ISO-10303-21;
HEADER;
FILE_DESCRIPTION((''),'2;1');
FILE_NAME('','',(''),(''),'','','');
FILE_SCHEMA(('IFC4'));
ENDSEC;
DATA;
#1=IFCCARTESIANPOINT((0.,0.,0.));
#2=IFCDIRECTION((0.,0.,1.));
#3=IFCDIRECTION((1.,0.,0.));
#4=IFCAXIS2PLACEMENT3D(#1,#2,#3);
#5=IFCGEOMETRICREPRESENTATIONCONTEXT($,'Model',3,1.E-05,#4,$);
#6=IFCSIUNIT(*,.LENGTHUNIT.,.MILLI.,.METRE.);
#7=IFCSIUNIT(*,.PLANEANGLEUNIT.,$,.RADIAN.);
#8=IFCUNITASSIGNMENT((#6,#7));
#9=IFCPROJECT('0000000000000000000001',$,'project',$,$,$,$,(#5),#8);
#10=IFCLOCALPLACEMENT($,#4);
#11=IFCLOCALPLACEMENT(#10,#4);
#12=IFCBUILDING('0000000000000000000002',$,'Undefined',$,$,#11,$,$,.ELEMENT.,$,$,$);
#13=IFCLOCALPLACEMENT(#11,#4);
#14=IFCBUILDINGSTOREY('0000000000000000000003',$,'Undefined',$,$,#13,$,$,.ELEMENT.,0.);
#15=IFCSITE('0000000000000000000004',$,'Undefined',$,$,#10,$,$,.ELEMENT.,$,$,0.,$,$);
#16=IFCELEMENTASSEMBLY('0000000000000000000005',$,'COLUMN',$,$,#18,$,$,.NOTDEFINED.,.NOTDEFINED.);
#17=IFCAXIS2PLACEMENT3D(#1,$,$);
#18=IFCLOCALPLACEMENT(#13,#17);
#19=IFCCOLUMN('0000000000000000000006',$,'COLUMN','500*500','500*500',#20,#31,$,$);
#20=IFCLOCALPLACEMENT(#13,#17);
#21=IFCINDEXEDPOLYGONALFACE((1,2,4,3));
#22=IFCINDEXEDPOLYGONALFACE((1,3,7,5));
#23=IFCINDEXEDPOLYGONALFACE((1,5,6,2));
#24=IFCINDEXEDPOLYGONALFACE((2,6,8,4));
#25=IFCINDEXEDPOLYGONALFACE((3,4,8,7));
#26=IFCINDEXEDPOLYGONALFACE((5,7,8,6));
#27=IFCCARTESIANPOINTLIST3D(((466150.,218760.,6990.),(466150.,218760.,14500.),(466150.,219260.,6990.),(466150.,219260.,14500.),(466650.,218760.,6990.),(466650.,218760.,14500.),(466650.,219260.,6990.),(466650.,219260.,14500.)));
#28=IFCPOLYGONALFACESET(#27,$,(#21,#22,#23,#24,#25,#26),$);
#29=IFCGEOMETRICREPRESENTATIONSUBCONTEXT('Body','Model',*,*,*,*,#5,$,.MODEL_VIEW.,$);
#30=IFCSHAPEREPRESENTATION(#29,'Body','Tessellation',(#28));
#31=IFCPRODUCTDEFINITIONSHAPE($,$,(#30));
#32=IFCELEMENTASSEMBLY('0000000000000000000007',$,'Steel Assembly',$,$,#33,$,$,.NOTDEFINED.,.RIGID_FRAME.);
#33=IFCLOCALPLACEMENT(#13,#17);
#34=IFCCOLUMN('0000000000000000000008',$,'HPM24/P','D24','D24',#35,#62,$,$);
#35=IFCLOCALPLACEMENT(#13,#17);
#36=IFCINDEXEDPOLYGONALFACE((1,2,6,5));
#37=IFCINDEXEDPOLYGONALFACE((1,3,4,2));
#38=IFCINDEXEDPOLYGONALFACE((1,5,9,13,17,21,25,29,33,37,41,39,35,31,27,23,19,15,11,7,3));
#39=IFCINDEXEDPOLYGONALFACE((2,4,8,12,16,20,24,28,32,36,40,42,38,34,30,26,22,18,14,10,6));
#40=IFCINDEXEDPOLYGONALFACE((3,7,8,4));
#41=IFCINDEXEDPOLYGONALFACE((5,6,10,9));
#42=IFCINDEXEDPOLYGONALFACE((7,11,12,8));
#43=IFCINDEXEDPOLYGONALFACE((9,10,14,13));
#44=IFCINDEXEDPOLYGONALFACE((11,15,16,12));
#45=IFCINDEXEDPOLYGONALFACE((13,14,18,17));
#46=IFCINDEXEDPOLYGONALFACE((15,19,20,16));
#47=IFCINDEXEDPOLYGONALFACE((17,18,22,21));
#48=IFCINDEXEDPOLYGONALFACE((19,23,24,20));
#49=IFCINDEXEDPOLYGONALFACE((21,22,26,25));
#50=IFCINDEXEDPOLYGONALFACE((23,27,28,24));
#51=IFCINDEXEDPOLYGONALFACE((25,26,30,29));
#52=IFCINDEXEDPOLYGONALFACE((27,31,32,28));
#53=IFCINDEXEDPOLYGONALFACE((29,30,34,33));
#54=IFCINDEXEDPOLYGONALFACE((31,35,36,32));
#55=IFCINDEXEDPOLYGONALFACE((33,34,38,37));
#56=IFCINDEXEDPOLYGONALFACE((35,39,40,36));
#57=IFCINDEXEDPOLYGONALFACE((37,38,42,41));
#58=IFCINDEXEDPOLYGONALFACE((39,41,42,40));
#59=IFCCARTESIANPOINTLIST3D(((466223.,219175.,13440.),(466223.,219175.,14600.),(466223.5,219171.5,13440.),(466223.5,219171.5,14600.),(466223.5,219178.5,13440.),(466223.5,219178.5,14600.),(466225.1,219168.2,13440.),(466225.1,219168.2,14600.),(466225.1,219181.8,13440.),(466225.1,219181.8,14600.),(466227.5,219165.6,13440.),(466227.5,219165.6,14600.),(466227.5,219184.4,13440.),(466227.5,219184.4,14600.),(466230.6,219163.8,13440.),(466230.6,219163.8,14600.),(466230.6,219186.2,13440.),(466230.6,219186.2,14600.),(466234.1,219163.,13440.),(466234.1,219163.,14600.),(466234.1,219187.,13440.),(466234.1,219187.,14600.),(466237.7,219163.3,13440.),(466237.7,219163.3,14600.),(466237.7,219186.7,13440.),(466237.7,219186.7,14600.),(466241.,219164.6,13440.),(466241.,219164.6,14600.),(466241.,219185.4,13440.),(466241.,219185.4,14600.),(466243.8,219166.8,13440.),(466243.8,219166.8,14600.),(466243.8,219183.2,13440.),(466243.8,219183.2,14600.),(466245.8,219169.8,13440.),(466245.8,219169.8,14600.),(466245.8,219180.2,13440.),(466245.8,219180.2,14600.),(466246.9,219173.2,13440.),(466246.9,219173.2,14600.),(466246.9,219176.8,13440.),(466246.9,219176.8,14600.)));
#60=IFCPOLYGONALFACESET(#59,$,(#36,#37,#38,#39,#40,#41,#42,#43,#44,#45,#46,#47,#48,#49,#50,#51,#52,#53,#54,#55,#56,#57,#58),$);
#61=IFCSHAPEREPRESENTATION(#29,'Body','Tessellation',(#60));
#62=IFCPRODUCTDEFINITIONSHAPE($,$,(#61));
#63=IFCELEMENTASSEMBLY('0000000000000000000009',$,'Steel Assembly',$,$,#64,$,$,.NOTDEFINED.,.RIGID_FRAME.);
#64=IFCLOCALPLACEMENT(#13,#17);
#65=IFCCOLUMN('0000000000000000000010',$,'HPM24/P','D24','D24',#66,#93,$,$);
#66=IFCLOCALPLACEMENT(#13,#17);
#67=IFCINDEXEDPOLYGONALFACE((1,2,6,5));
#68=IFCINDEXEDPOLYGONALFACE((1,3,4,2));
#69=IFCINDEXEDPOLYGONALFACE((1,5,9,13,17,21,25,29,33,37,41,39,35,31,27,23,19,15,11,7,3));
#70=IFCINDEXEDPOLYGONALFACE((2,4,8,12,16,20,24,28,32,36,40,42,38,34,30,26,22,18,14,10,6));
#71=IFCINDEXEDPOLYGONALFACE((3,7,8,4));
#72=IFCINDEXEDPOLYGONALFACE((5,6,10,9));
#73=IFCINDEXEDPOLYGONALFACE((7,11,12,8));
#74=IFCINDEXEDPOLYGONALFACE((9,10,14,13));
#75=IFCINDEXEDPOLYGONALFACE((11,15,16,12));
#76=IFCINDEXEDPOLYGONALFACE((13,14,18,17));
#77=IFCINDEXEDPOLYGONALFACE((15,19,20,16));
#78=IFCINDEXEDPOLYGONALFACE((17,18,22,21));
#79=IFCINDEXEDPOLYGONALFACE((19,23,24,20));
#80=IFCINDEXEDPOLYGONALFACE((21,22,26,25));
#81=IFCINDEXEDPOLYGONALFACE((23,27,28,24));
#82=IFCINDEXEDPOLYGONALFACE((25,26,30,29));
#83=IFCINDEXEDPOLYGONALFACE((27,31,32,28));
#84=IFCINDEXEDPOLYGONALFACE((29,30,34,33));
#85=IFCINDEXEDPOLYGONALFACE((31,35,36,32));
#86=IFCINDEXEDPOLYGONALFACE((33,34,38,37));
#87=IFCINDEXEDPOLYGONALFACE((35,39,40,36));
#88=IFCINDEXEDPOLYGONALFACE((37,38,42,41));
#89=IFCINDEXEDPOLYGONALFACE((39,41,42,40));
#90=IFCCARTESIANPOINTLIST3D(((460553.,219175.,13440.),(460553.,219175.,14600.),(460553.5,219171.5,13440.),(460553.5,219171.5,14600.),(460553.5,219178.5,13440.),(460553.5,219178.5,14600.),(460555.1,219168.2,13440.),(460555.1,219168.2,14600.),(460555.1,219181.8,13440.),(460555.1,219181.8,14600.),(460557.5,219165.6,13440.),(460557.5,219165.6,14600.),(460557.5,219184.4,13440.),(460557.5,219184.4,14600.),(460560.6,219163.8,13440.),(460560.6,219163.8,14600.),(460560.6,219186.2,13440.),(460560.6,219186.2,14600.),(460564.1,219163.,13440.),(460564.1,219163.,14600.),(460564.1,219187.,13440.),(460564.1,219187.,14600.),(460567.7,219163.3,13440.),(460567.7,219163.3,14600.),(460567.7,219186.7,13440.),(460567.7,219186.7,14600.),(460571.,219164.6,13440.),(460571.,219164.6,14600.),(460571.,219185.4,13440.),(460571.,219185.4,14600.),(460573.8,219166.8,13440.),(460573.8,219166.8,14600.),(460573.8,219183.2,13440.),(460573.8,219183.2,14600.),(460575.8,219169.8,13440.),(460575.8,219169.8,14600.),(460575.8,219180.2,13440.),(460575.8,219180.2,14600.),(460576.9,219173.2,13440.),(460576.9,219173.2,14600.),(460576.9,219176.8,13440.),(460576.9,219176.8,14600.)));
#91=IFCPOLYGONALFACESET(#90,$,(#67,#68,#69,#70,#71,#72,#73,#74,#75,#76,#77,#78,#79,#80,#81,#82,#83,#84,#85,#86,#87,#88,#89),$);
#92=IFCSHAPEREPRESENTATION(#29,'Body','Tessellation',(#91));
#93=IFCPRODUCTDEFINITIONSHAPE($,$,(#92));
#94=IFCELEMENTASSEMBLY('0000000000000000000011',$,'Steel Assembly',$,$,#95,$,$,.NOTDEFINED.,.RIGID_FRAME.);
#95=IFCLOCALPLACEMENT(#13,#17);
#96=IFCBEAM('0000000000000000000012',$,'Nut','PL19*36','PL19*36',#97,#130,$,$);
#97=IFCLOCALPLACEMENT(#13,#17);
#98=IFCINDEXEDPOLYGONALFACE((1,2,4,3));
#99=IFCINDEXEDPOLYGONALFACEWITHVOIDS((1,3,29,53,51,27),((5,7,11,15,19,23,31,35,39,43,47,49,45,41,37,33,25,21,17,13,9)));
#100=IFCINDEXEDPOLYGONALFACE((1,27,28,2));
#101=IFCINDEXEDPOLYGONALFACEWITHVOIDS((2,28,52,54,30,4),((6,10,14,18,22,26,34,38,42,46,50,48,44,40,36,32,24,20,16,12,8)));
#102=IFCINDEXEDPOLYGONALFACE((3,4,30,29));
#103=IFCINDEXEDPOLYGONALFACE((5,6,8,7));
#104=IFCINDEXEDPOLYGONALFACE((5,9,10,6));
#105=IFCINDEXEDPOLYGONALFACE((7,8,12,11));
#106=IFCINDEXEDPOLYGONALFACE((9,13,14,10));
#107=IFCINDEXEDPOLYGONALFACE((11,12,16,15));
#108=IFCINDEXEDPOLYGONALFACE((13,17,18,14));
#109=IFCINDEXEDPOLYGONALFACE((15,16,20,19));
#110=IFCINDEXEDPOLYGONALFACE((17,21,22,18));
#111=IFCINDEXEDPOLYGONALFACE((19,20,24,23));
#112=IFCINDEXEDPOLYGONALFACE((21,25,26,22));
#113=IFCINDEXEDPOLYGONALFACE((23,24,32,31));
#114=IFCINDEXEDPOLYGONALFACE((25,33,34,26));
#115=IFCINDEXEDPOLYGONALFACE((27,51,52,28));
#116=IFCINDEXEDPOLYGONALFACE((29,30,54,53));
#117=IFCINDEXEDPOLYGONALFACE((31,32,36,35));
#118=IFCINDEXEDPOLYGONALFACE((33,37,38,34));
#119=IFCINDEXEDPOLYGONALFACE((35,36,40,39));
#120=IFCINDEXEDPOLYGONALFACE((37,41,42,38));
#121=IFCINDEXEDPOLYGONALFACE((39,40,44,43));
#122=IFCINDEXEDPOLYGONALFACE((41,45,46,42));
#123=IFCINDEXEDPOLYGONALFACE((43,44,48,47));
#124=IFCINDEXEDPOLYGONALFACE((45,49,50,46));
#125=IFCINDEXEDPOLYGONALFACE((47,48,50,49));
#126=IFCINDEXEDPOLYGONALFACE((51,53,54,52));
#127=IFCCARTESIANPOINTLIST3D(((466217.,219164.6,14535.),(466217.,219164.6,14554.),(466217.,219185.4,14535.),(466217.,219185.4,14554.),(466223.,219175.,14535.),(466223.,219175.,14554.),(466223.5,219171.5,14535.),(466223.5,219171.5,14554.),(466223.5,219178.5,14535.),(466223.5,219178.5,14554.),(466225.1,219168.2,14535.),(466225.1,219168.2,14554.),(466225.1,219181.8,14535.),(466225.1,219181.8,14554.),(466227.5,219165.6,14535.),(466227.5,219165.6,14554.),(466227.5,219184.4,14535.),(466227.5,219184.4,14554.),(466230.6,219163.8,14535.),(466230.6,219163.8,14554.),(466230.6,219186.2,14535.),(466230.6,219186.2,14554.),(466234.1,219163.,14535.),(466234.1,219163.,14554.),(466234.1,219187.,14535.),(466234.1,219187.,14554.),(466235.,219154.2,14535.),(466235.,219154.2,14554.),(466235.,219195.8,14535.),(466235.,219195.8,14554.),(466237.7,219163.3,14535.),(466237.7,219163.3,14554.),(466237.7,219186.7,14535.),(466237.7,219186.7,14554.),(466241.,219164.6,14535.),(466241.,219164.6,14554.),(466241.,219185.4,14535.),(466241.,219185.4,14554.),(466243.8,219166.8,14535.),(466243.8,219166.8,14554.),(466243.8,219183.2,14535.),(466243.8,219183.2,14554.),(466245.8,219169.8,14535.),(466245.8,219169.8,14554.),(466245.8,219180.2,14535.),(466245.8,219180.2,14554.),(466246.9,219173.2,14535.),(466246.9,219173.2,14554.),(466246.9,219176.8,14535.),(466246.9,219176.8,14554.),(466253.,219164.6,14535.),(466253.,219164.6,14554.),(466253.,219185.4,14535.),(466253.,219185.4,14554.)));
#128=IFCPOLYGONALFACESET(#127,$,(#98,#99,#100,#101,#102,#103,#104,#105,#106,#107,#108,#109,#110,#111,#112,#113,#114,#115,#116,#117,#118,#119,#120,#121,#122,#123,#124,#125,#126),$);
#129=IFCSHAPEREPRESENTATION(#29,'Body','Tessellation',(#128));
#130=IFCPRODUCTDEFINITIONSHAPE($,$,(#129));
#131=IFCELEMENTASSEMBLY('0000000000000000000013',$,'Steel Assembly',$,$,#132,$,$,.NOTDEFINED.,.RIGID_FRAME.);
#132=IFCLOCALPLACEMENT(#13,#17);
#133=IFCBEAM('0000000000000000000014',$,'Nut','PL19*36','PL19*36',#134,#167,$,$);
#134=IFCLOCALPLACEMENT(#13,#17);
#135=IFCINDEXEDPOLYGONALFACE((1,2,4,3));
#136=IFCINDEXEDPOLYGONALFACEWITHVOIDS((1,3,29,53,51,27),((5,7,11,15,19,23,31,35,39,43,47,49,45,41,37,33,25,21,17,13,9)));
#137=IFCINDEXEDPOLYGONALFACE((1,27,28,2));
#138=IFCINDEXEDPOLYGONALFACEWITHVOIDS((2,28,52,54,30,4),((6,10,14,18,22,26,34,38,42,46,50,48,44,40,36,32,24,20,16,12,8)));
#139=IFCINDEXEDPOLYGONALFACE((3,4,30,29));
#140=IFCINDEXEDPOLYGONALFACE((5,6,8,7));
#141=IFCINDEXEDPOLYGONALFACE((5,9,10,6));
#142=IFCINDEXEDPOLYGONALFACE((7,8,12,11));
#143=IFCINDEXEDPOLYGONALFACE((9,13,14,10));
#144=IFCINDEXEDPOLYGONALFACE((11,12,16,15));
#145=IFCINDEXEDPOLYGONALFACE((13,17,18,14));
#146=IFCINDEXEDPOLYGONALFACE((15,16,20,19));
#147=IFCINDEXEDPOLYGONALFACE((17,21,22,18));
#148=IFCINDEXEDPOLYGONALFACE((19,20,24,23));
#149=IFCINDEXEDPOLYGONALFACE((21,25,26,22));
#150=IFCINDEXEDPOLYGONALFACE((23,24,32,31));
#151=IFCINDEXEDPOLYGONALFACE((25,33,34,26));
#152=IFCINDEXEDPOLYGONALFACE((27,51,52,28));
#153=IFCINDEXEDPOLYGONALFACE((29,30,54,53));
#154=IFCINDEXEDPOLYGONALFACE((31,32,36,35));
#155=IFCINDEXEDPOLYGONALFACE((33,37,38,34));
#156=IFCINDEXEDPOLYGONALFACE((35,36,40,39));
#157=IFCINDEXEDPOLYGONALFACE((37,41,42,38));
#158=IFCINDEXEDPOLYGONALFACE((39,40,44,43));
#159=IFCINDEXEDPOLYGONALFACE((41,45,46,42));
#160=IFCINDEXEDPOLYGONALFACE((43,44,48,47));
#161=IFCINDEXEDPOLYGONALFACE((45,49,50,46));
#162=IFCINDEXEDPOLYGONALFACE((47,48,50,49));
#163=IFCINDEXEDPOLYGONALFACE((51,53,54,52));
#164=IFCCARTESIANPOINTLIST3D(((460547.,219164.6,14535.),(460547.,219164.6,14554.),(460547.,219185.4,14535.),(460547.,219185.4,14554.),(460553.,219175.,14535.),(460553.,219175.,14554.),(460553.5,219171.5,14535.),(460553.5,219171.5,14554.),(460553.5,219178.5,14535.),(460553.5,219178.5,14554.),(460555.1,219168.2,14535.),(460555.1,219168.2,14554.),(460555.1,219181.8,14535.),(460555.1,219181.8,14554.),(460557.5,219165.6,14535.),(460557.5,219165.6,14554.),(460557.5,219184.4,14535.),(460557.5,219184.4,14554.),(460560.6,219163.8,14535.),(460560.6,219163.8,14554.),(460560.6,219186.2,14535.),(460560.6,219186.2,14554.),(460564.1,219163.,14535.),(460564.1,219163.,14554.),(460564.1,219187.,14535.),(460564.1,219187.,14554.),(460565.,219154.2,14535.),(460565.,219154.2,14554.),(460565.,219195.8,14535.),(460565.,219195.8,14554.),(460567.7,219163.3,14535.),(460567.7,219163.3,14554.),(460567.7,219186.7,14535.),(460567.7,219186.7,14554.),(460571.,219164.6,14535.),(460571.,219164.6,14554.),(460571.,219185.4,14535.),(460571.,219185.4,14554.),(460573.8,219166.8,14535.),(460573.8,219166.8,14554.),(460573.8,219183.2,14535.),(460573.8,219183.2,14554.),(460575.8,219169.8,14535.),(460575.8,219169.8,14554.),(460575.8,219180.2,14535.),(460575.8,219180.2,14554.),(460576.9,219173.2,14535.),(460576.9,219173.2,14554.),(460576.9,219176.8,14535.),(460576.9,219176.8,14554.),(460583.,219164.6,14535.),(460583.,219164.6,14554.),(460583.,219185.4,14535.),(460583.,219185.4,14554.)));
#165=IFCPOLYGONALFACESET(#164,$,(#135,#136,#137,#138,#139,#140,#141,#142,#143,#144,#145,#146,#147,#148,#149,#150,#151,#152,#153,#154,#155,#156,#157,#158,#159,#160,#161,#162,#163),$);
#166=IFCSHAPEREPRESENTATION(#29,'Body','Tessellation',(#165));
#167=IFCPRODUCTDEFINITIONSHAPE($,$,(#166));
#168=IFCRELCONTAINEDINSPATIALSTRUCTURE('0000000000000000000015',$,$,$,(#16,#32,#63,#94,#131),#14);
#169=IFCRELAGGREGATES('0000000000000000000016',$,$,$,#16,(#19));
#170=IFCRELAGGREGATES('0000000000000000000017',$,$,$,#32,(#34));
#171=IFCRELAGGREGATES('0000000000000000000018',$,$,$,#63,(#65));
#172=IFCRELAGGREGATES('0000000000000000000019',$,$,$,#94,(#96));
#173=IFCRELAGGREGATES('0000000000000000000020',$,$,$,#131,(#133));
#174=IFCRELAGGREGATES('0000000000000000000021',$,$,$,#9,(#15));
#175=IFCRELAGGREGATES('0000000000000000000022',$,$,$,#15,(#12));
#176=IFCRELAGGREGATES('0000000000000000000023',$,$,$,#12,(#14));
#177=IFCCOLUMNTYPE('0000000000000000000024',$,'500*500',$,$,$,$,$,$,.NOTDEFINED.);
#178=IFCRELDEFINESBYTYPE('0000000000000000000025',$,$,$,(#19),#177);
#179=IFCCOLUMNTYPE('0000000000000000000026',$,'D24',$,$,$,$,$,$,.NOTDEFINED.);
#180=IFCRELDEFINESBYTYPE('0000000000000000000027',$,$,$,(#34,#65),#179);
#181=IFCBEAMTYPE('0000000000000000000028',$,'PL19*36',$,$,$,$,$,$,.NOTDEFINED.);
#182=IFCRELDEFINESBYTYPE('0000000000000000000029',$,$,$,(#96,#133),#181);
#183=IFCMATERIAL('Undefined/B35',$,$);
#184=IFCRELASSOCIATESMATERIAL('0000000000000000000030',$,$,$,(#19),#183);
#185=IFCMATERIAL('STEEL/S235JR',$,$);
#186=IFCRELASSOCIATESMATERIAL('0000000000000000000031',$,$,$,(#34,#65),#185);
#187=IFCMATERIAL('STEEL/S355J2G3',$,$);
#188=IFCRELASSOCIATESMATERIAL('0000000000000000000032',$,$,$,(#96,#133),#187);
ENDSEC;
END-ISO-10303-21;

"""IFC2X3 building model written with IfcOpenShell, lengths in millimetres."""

from ifc_helpers import new_model, si_unit, frame, origin_with_axes, origin_2d_with_axis, place, context, subcontext, project, spatial, rectangle, circle, extrude, boolean, halfspace, material, type_object, element, aggregate, save


model = new_model("IFC2X3")

# Units and contexts
model_context = context("Model", 3, precision=1e-05, world=origin_with_axes())
body_context = subcontext(model_context, "Body", "Model", "MODEL_VIEW")
ifc_project = project(units=[si_unit("LENGTHUNIT", "METRE", prefix="MILLI"), si_unit("PLANEANGLEUNIT", "RADIAN")], contexts=[model_context])

# Site, building, storey
site_placement = place(None, origin_with_axes())
site = spatial("IfcSite", under=ifc_project, at=site_placement, Name="Undefined", CompositionType="ELEMENT", RefElevation=0.0)
building_placement = place(site_placement, origin_with_axes())
building = spatial("IfcBuilding", under=site, at=building_placement, Name="Undefined", CompositionType="ELEMENT")
storey_placement = place(building_placement, origin_with_axes())
storey = spatial("IfcBuildingStorey", under=building, at=storey_placement, Name="Undefined", CompositionType="ELEMENT", Elevation=0.0)

# Element assemblies, columns
assembly_1_placement = place(storey_placement, origin_with_axes())
assembly_1 = element("IfcElementAssembly", 1, at=assembly_1_placement, inside=storey, Name="COLUMN", AssemblyPlace="NOTDEFINED", PredefinedType="NOTDEFINED")
ifc_material_1 = material(Name="Undefined/B35")
column_type_1 = type_object("IfcColumnType", Name="500*500", PredefinedType="NOTDEFINED")
column_1_placement = place(assembly_1_placement, frame((466400.0, 219010.0, 6990.0), z_axis=(0.0, 0.0, 1.0), x_axis=(1.0, 0.0, 0.0)))
column_1 = element("IfcColumn", 2, at=column_1_placement, type_object=column_type_1, material=ifc_material_1, Name="COLUMN", Description="500*500", ObjectType="500*500", context=body_context, shape_type="SweptSolid", body=[
    extrude(rectangle(XDim=500.0, YDim=500.0, at=origin_2d_with_axis()), frame((0.0, 0.0, 7510.0), z_axis=(0.0, 0.0, -1.0), x_axis=(-1.0, 0.0, 0.0)), (0.0, 0.0, 1.0), 7510.0),
])
aggregate(assembly_1, [column_1])
assembly_2_placement = place(storey_placement, origin_with_axes())
assembly_2 = element("IfcElementAssembly", 3, at=assembly_2_placement, inside=storey, Name="Steel Assembly", AssemblyPlace="NOTDEFINED", PredefinedType="RIGID_FRAME")
ifc_material_2 = material(Name="STEEL/S235JR")
column_type_2 = type_object("IfcColumnType", Name="D24", PredefinedType="NOTDEFINED")
column_2_placement = place(assembly_2_placement, frame((466235.0, 219175.0, 13440.0), z_axis=(0.0, 0.0, 1.0), x_axis=(1.0, 0.0, 0.0)))
column_2 = element("IfcColumn", 4, at=column_2_placement, type_object=column_type_2, material=ifc_material_2, Name="HPM24/P", Description="D24", ObjectType="D24", context=body_context, shape_type="SweptSolid", body=[
    extrude(circle(Radius=12.0, at=origin_2d_with_axis()), frame((0.0, 0.0, 1160.0), z_axis=(0.0, 0.0, -1.0), x_axis=(-1.0, 0.0, 0.0)), (0.0, 0.0, 1.0), 1160.0),
])
aggregate(assembly_2, [column_2])
assembly_3_placement = place(storey_placement, origin_with_axes())
assembly_3 = element("IfcElementAssembly", 5, at=assembly_3_placement, inside=storey, Name="Steel Assembly", AssemblyPlace="NOTDEFINED", PredefinedType="RIGID_FRAME")
column_3_placement = place(assembly_3_placement, frame((460565.0, 219175.0, 13440.0), z_axis=(0.0, 0.0, 1.0), x_axis=(1.0, 0.0, 0.0)))
column_3 = element("IfcColumn", 6, at=column_3_placement, type_object=column_type_2, material=ifc_material_2, Name="HPM24/P", Description="D24", ObjectType="D24", context=body_context, shape_type="SweptSolid", body=[
    extrude(circle(Radius=12.0, at=origin_2d_with_axis()), frame((0.0, 0.0, 1160.0), z_axis=(0.0, 0.0, -1.0), x_axis=(-1.0, 0.0, 0.0)), (0.0, 0.0, 1.0), 1160.0),
])
aggregate(assembly_3, [column_3])

# Element assemblies, beams
assembly_4_placement = place(storey_placement, origin_with_axes())
assembly_4 = element("IfcElementAssembly", 7, at=assembly_4_placement, inside=storey, Name="Steel Assembly", AssemblyPlace="NOTDEFINED", PredefinedType="RIGID_FRAME")
ifc_material_3 = material(Name="STEEL/S355J2G3")
beam_type_1 = type_object("IfcBeamType", Name="PL19*36", PredefinedType="NOTDEFINED")
beam_1_placement = place(assembly_4_placement, frame((466235.0, 219195.8, 14544.5), z_axis=(-1.0, 0.0, 0.0), x_axis=(0.0, -1.0, 0.0)))
beam_1 = element("IfcBeam", 8, at=beam_1_placement, type_object=beam_type_1, material=ifc_material_3, Name="Nut", Description="PL19*36", ObjectType="PL19*36", context=body_context, shape_type="CSG", body=[
    boolean("DIFFERENCE", boolean("DIFFERENCE", boolean("DIFFERENCE", boolean("DIFFERENCE", boolean("DIFFERENCE", extrude(rectangle(XDim=19.0, YDim=36.0, at=origin_2d_with_axis()), frame((41.6, 0.0, 0.0), z_axis=(-1.0, 0.0, 0.0), x_axis=(0.0, -1.0, 0.0)), (0.0, 0.0, 1.0), 41.6), extrude(circle(Radius=12.0, at=origin_2d_with_axis()), frame((20.8, -9.5, 0.0), z_axis=(0.0, 1.0, 0.0), x_axis=(0.0, 0.0, 1.0)), (0.0, 0.0, 1.0), 19.0)), halfspace(frame((31.2, -9.5, -18.0), z_axis=(0.865865, 0.0, -0.500278), x_axis=(0.500278, 0.0, 0.865865)), False)), halfspace(frame((52.0, -9.5, -18.0), z_axis=(0.865865, 0.0, 0.500278), x_axis=(-0.500278, 0.0, 0.865865)), False)), halfspace(frame((-10.4, 9.5, -18.0), z_axis=(-0.865865, 0.0, 0.500278), x_axis=(0.500278, 0.0, 0.865865)), False)), halfspace(frame((10.4, 9.5, -18.0), z_axis=(-0.865865, 0.0, -0.500278), x_axis=(-0.500278, 0.0, 0.865865)), False)),
])
aggregate(assembly_4, [beam_1])
assembly_5_placement = place(storey_placement, origin_with_axes())
assembly_5 = element("IfcElementAssembly", 9, at=assembly_5_placement, inside=storey, Name="Steel Assembly", AssemblyPlace="NOTDEFINED", PredefinedType="RIGID_FRAME")
beam_2_placement = place(assembly_5_placement, frame((460565.0, 219195.8, 14544.5), z_axis=(-1.0, 0.0, 0.0), x_axis=(0.0, -1.0, 0.0)))
beam_2 = element("IfcBeam", 10, at=beam_2_placement, type_object=beam_type_1, material=ifc_material_3, Name="Nut", Description="PL19*36", ObjectType="PL19*36", context=body_context, shape_type="CSG", body=[
    boolean("DIFFERENCE", boolean("DIFFERENCE", boolean("DIFFERENCE", boolean("DIFFERENCE", boolean("DIFFERENCE", extrude(rectangle(XDim=19.0, YDim=36.0, at=origin_2d_with_axis()), frame((41.6, 0.0, 0.0), z_axis=(-1.0, 0.0, 0.0), x_axis=(0.0, -1.0, 0.0)), (0.0, 0.0, 1.0), 41.6), extrude(circle(Radius=12.0, at=origin_2d_with_axis()), frame((20.8, -9.5, 0.0), z_axis=(0.0, 1.0, 0.0), x_axis=(0.0, 0.0, 1.0)), (0.0, 0.0, 1.0), 19.0)), halfspace(frame((31.2, -9.5, -18.0), z_axis=(0.865865, 0.0, -0.500278), x_axis=(0.500278, 0.0, 0.865865)), False)), halfspace(frame((52.0, -9.5, -18.0), z_axis=(0.865865, 0.0, 0.500278), x_axis=(-0.500278, 0.0, 0.865865)), False)), halfspace(frame((-10.4, 9.5, -18.0), z_axis=(-0.865865, 0.0, 0.500278), x_axis=(0.500278, 0.0, 0.865865)), False)), halfspace(frame((10.4, 9.5, -18.0), z_axis=(-0.865865, 0.0, -0.500278), x_axis=(-0.500278, 0.0, 0.865865)), False)),
])
aggregate(assembly_5, [beam_2])

save(model, "model.ifc")
